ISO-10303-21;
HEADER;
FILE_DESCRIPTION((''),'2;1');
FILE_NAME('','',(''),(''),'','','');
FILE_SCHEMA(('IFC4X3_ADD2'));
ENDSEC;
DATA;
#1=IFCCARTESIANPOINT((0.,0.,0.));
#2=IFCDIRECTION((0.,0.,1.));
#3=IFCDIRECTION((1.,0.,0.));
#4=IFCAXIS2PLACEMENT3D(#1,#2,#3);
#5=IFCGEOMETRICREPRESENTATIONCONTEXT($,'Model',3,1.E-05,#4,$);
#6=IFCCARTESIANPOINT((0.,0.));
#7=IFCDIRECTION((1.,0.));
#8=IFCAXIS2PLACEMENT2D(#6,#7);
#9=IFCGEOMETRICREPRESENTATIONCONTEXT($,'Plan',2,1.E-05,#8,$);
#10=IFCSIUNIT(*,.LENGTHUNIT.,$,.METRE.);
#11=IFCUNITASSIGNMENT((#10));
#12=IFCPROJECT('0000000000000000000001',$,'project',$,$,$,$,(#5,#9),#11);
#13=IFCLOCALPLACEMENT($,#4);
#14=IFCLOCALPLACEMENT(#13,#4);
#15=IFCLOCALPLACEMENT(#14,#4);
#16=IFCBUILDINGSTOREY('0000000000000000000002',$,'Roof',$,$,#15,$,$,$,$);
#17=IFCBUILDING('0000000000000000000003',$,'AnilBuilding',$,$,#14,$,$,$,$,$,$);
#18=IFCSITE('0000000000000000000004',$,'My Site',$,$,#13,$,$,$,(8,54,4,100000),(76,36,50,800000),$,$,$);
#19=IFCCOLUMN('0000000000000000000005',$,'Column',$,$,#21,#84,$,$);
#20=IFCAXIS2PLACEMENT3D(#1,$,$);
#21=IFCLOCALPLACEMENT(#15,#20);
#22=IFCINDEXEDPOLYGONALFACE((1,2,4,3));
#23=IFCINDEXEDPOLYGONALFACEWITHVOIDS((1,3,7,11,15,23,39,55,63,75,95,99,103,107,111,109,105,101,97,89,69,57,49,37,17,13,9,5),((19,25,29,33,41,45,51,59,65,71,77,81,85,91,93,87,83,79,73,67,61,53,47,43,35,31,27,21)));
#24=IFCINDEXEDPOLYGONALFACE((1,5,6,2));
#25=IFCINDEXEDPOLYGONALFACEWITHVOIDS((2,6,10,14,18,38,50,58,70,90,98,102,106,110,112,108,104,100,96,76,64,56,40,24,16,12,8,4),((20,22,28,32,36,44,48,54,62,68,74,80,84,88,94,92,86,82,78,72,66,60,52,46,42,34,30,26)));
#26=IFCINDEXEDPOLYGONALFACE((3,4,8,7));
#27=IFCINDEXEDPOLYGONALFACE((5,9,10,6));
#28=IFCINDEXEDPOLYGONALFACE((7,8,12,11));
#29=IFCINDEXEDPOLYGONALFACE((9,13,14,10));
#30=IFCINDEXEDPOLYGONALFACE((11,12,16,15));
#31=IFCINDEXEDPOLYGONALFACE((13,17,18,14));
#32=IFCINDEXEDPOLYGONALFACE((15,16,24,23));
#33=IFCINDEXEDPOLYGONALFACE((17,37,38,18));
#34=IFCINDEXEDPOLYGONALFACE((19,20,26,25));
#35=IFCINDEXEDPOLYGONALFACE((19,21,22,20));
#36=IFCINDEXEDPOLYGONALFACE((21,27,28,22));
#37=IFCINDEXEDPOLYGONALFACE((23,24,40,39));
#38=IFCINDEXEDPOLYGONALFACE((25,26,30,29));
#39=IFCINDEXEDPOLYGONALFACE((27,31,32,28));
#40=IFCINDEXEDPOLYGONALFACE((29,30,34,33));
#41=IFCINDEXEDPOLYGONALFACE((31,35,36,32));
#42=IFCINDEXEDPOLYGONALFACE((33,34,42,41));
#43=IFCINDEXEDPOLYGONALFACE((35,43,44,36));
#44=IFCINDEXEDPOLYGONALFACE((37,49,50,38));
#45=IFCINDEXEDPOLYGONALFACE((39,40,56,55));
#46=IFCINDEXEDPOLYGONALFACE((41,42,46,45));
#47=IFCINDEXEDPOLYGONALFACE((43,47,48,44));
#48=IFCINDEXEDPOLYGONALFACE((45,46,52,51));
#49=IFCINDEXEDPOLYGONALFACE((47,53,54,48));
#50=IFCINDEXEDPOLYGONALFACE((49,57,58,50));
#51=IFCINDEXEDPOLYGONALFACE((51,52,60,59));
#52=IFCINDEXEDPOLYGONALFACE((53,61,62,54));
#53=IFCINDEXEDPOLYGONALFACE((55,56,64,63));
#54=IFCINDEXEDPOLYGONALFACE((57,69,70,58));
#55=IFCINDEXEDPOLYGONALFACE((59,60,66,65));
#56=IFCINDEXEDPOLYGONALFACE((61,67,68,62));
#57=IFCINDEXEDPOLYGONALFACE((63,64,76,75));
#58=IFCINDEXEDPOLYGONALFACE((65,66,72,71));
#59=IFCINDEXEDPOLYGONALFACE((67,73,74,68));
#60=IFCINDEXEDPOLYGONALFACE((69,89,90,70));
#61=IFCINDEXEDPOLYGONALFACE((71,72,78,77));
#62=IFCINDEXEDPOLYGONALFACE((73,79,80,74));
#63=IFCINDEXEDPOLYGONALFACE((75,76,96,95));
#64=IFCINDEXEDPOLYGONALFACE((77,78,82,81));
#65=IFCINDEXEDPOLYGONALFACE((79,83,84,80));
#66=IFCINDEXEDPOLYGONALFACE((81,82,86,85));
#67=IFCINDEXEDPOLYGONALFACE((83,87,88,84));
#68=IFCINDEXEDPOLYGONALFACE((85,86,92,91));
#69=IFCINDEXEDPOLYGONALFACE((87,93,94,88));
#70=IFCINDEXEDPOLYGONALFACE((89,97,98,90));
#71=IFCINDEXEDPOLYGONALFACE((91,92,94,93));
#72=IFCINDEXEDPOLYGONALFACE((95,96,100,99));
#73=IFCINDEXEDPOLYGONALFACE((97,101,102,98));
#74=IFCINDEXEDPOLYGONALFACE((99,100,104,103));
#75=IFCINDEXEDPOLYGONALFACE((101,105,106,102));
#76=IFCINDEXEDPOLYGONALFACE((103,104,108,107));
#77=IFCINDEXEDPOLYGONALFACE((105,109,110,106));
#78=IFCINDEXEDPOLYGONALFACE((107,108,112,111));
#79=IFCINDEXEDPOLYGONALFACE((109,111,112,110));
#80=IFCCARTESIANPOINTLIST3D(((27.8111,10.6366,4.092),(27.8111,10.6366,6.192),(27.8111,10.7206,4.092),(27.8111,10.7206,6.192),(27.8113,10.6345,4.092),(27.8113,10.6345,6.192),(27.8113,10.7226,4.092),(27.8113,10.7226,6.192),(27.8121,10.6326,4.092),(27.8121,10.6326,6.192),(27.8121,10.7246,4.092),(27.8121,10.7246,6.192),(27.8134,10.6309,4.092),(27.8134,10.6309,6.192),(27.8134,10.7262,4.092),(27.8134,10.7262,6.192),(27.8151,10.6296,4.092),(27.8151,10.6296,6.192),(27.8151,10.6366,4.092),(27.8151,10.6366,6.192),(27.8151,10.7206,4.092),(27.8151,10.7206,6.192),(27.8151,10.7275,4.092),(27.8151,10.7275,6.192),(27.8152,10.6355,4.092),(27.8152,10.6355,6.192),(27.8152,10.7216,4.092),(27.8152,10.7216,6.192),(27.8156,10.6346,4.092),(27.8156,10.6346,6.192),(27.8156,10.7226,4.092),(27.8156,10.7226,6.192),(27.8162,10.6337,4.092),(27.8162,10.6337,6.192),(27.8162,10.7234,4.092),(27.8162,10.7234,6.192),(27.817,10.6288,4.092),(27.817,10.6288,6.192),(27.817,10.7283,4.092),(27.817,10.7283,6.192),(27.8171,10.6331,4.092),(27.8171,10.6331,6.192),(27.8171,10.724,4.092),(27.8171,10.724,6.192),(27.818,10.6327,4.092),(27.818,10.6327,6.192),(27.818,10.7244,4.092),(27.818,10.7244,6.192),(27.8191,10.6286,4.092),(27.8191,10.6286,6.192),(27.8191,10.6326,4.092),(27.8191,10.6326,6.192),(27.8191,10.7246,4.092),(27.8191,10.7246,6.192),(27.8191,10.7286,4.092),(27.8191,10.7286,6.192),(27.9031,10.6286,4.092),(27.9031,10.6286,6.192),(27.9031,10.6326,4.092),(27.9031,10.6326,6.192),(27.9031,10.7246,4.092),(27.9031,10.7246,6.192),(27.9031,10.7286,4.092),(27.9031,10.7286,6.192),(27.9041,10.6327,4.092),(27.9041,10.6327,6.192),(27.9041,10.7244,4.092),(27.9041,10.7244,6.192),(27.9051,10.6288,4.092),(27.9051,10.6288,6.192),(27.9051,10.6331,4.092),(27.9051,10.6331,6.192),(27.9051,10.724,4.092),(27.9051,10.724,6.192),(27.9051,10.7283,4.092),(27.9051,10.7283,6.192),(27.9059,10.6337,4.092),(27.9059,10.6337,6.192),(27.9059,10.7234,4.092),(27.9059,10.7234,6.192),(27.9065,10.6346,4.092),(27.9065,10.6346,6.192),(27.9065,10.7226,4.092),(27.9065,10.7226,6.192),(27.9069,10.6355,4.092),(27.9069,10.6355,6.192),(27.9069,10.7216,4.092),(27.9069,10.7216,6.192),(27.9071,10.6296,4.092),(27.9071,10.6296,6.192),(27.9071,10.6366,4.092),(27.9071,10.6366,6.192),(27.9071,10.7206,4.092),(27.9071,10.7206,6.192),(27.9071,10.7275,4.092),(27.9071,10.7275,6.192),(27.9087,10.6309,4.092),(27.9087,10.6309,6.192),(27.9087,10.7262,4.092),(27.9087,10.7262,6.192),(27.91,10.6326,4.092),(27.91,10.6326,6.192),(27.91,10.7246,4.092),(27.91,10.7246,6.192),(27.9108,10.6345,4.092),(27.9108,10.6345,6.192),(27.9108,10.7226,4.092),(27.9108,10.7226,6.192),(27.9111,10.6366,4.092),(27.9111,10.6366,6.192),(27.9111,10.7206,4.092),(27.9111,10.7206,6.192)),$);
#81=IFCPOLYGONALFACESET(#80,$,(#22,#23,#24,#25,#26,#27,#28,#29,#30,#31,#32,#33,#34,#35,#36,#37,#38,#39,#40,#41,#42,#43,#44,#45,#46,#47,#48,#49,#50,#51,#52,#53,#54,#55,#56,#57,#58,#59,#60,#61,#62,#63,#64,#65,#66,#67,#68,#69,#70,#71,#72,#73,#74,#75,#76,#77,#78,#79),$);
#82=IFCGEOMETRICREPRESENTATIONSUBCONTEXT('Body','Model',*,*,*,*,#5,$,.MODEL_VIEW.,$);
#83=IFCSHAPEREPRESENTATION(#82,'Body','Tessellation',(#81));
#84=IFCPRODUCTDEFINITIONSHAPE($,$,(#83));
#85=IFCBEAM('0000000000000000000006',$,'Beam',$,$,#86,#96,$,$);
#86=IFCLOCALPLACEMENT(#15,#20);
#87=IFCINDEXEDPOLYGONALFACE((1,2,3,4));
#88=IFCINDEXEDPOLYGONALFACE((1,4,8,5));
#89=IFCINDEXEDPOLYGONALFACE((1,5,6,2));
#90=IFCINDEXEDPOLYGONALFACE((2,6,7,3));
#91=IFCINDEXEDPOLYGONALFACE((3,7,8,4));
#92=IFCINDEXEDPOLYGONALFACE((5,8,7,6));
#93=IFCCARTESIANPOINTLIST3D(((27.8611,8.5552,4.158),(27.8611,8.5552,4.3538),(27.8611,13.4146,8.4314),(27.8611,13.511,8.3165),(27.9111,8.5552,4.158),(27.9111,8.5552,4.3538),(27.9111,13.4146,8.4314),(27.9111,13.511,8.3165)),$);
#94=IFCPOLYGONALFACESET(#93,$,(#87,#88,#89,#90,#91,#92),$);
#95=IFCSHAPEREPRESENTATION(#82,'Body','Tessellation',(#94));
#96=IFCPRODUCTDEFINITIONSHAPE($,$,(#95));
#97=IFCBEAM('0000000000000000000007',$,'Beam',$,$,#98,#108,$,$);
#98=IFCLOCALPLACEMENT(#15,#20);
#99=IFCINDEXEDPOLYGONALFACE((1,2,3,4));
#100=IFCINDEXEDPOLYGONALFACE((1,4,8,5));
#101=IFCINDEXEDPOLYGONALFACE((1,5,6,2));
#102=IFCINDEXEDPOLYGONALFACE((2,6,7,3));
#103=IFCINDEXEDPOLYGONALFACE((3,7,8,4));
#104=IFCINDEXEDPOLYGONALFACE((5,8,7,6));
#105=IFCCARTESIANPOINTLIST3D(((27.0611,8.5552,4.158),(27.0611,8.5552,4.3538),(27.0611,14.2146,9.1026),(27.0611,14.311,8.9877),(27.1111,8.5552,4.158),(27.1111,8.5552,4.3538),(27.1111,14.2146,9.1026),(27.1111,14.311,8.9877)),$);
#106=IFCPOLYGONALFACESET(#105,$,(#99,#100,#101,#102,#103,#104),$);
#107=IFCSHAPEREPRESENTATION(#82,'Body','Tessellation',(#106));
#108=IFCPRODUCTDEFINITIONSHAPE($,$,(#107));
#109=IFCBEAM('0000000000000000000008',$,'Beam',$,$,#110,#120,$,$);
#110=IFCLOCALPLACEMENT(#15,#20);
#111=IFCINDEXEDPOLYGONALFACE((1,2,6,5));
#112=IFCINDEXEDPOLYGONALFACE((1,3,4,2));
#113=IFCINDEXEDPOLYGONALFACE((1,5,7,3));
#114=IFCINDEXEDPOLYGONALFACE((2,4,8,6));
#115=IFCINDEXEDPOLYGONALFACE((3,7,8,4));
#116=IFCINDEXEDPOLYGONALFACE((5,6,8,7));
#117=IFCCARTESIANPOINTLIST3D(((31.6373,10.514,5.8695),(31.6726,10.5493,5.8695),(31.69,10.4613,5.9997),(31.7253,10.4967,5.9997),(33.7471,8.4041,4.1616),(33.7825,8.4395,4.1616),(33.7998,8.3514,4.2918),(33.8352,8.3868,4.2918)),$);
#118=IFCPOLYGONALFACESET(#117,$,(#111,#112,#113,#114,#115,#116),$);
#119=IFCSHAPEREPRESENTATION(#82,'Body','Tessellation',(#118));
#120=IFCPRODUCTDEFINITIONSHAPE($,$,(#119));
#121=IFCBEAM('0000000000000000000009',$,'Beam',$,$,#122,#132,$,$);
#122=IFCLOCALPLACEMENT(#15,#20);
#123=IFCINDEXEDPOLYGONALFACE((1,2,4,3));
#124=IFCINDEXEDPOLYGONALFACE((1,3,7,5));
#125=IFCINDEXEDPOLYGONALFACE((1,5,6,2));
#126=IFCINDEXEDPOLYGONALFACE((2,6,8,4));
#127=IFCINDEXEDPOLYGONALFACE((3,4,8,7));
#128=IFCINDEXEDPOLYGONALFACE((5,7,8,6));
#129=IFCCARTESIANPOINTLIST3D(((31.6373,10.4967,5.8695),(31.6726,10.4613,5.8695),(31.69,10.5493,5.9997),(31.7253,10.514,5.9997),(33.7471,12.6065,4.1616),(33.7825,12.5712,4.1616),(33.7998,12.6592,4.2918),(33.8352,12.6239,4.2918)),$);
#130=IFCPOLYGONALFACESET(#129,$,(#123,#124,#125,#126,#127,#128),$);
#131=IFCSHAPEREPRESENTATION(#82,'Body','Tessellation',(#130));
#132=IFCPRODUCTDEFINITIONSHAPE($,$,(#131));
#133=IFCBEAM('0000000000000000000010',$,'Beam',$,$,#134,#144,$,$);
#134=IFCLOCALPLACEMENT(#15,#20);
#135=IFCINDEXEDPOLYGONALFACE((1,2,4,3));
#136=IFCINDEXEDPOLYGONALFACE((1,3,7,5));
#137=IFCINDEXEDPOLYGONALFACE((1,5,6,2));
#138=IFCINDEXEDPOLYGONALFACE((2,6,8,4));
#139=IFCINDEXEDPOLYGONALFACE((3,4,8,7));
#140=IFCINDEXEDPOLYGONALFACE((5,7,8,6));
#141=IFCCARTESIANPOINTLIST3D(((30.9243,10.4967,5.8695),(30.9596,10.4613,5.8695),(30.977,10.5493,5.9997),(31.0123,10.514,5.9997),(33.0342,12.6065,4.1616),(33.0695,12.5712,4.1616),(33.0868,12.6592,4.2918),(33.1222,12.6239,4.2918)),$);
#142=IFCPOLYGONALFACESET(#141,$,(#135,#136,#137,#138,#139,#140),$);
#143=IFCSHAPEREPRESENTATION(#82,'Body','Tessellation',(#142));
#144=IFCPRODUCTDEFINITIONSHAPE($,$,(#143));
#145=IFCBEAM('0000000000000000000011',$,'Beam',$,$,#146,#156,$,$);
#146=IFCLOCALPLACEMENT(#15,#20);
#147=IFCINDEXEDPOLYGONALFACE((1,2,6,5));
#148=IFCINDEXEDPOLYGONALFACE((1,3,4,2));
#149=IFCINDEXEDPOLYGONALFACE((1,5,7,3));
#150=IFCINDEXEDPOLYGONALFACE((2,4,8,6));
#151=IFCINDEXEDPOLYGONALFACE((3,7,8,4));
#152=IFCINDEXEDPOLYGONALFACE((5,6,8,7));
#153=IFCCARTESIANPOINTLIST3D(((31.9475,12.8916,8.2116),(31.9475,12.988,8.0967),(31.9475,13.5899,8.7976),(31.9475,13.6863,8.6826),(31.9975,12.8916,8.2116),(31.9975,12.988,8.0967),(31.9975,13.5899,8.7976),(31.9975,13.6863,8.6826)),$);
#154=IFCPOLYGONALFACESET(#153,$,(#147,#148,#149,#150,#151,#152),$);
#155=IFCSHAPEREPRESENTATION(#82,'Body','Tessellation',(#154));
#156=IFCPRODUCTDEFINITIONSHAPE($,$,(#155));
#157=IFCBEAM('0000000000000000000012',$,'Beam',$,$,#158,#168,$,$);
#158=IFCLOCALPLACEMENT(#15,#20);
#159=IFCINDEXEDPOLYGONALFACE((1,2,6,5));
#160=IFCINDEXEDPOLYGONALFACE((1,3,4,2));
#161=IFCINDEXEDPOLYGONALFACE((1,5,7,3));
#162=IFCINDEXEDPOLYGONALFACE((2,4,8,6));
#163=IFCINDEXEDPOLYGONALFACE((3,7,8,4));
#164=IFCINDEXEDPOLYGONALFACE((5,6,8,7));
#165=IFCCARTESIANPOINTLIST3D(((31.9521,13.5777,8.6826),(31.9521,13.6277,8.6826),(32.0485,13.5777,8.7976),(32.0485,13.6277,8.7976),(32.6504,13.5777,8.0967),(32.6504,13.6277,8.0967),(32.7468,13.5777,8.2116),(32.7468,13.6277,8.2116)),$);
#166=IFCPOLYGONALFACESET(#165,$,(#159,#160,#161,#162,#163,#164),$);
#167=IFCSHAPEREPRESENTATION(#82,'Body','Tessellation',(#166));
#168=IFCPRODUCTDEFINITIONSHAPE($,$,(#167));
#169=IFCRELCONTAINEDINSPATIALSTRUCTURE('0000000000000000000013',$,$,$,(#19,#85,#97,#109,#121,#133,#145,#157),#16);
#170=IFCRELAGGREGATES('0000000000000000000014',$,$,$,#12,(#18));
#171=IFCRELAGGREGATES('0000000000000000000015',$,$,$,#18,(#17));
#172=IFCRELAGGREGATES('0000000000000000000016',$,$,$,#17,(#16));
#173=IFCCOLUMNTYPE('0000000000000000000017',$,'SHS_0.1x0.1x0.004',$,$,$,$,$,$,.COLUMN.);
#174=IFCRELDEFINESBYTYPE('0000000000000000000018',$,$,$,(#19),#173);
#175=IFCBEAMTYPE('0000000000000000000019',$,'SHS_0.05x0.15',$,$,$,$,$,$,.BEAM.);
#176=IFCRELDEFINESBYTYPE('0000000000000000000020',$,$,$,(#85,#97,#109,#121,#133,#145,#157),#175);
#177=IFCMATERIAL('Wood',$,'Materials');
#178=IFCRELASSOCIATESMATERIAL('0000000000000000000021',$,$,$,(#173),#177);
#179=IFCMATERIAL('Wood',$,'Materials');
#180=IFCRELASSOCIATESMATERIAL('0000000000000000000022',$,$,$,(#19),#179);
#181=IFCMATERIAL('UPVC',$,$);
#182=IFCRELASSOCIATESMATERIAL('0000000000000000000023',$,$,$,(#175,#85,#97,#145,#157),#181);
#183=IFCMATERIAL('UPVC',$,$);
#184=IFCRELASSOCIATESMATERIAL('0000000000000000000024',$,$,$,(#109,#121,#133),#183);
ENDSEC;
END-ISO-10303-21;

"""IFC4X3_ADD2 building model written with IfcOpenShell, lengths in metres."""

from ifc_helpers import new_model, entity, si_unit, frame, origin_with_axes, origin_2d_with_axis, place, context, subcontext, project, spatial, indexed_curve, hollow_rectangle, outline, extrude, clip, halfspace, shape, material, material_profile, profile_set, profile_usage, type_object, element, save


model = new_model("IFC4X3_ADD2")

# Units and contexts
model_context = context("Model", 3, precision=1e-05, world=origin_with_axes())
plan_context = context("Plan", 2, precision=1e-05, world=origin_2d_with_axis())
body_context_1 = subcontext(model_context, "Body", "Model", "MODEL_VIEW")
body_context_2 = subcontext(plan_context, "Body", "Plan", "PLAN_VIEW")
ifc_project = project(units=[si_unit("LENGTHUNIT", "METRE")], contexts=[model_context, plan_context])

# Site, building, storey
site_placement = place(None, origin_with_axes())
site = spatial("IfcSite", under=ifc_project, at=site_placement, Name="My Site", RefLatitude=(8, 54, 4, 100000), RefLongitude=(76, 36, 50, 800000))
building_placement = place(site_placement, origin_with_axes())
building = spatial("IfcBuilding", under=site, at=building_placement, Name="AnilBuilding")
storey_placement = place(building_placement, origin_with_axes())
storey = spatial("IfcBuildingStorey", under=building, at=storey_placement, Name="Roof")

# Column
ifc_material_1 = material(Name="Wood", Category="Materials")
ifc_material_profile_1 = material_profile(ifc_material_1, hollow_rectangle(XDim=0.1, YDim=0.1, WallThickness=0.004, InnerFilletRadius=0.004, OuterFilletRadius=0.008))
ifc_profile_set_1 = profile_set([ifc_material_profile_1])
ifc_profile_usage_1 = profile_usage(ifc_profile_set_1)
ifc_material_2 = material(Name="Wood", Category="Materials")
ifc_material_profile_2 = material_profile(ifc_material_2, hollow_rectangle(XDim=0.1, YDim=0.1, WallThickness=0.004, InnerFilletRadius=0.004, OuterFilletRadius=0.008))
ifc_profile_set_2 = profile_set([ifc_material_profile_2])
column_type = type_object("IfcColumnType", Name="SHS_0.1x0.1x0.004", PredefinedType="COLUMN", material=ifc_profile_set_2)
column_placement = place(storey_placement, frame((27.8611, 10.6786, 4.092), z_axis=(0.0, 0.0, 1.0), x_axis=(0.0, -1.0, 0.0)))
element("IfcColumn", 1, at=column_placement, inside=storey, type_object=column_type, material=ifc_profile_usage_1, Name="Column", shapes=[
    shape(body_context_1, "Body", "SweptSolid", [extrude(hollow_rectangle(XDim=0.1, YDim=0.1, WallThickness=0.004, InnerFilletRadius=0.004, OuterFilletRadius=0.008), origin_with_axes(), (0.0, 0.0, 1.0), 2.1)]),
    shape(body_context_2, "Body", "Annotation2D", [entity("IfcGeometricCurveSet", [entity("IfcIndexedPolyCurve", entity("IfcCartesianPointList2D", [[0.04, -0.04], [0.04, 0.04], [-0.04, 0.04], [-0.04, -0.04]]), [entity("IfcLineIndex", [1, 2, 3, 4, 1])]), entity("IfcIndexedPolyCurve", entity("IfcCartesianPointList2D", [[-0.05, -0.05], [0.05, -0.05], [0.05, 0.05], [-0.05, 0.05]]), [entity("IfcLineIndex", [1, 2, 3, 4, 1])])])]),
])

# Beams
ifc_material_3 = material(Name="UPVC")
ifc_material_profile_3 = material_profile(ifc_material_3, outline(indexed_curve([(-0.025, 0.075), (0.025, 0.075), (0.025, -0.075), (-0.025, -0.075), (-0.025, 0.075)])))
ifc_profile_set_3 = profile_set([ifc_material_profile_3])
ifc_profile_usage_2 = profile_usage(ifc_profile_set_3, cardinal=5)
beam_type = type_object("IfcBeamType", Name="SHS_0.05x0.15", PredefinedType="BEAM", material=ifc_profile_set_3)
beam_1_placement = place(storey_placement, frame((27.8861, 8.4403, 4.1595), z_axis=(0.000001, 0.766044, 0.642788), x_axis=(-1.0, 0.000001, 0.0)))
element("IfcBeam", 2, at=beam_1_placement, inside=storey, type_object=beam_type, material=ifc_profile_usage_2, Name="Beam", context=body_context_1, shape_type="Clipping", body=[
    clip(extrude(outline(indexed_curve([(-0.025, 0.075), (0.025, 0.075), (0.025, -0.075), (-0.025, -0.075), (-0.025, 0.075)])), origin_with_axes(), (0.0, 0.0, 1.0), 6.5565), halfspace(frame((12.1745, -0.0793, 0.0835), z_axis=(0.0, 0.642787, -0.766045), x_axis=(1.0, -0.000001, 0.0)), False)),
])
ifc_profile_usage_3 = profile_usage(ifc_profile_set_3, cardinal=5)
beam_2_placement = place(storey_placement, frame((27.0861, 8.4403, 4.1595), z_axis=(0.000001, 0.766044, 0.642788), x_axis=(-1.0, 0.000001, 0.0)))
element("IfcBeam", 3, at=beam_2_placement, inside=storey, type_object=beam_type, material=ifc_profile_usage_3, Name="Beam", context=body_context_1, shape_type="Clipping", body=[
    clip(extrude(outline(indexed_curve([(-0.025, 0.075), (0.025, 0.075), (0.025, -0.075), (-0.025, -0.075), (-0.025, 0.075)])), origin_with_axes(), (0.0, 0.0, 1.0), 7.6008), halfspace(frame((11.3745, -0.0793, 0.0835), z_axis=(0.0, 0.642787, -0.766045), x_axis=(1.0, -0.000001, 0.0)), False)),
])
ifc_material_4 = material(Name="UPVC")
ifc_material_profile_4 = material_profile(ifc_material_4, outline(indexed_curve([(-0.025, 0.075), (0.025, 0.075), (0.025, -0.075), (-0.025, -0.075), (-0.025, 0.075)])))
ifc_profile_set_4 = profile_set([ifc_material_profile_4])
ifc_profile_usage_4 = profile_usage(ifc_profile_set_4, cardinal=5)
beam_3_placement = place(storey_placement, frame((31.6813, 10.5053, 5.9346), z_axis=(0.61369, -0.613688, -0.496761), x_axis=(0.707106, 0.707107, 0.0)))
element("IfcBeam", 4, at=beam_3_placement, inside=storey, type_object=beam_type, material=ifc_profile_usage_4, Name="Beam", context=body_context_1, shape_type="SweptSolid", body=[
    extrude(outline(indexed_curve([(-0.025, 0.075), (0.025, 0.075), (0.025, -0.075), (-0.025, -0.075), (-0.025, 0.075)])), origin_with_axes(), (0.0, 0.0, 1.0), 3.438),
])
ifc_profile_usage_5 = profile_usage(ifc_profile_set_4, cardinal=5)
beam_4_placement = place(storey_placement, frame((31.6813, 10.5053, 5.9346), z_axis=(0.613688, 0.61369, -0.496761), x_axis=(-0.707108, 0.707106, 0.0)))
element("IfcBeam", 5, at=beam_4_placement, inside=storey, type_object=beam_type, material=ifc_profile_usage_5, Name="Beam", context=body_context_1, shape_type="SweptSolid", body=[
    extrude(outline(indexed_curve([(-0.025, 0.075), (0.025, 0.075), (0.025, -0.075), (-0.025, -0.075), (-0.025, 0.075)])), origin_with_axes(), (0.0, 0.0, 1.0), 3.438),
])
ifc_profile_usage_6 = profile_usage(ifc_profile_set_4, cardinal=5)
beam_5_placement = place(storey_placement, frame((30.9683, 10.5053, 5.9346), z_axis=(0.613688, 0.61369, -0.496761), x_axis=(-0.707108, 0.707106, 0.0)))
element("IfcBeam", 6, at=beam_5_placement, inside=storey, type_object=beam_type, material=ifc_profile_usage_6, Name="Beam", context=body_context_1, shape_type="SweptSolid", body=[
    extrude(outline(indexed_curve([(-0.025, 0.075), (0.025, 0.075), (0.025, -0.075), (-0.025, -0.075), (-0.025, 0.075)])), origin_with_axes(), (0.0, 0.0, 1.0), 3.438),
])
ifc_profile_usage_7 = profile_usage(ifc_profile_set_3, cardinal=5)
beam_6_placement = place(storey_placement, frame((31.9725, 13.6381, 8.7401), z_axis=(0.0, -0.766044, -0.642788), x_axis=(-1.0, 0.0, 0.0)))
element("IfcBeam", 7, at=beam_6_placement, inside=storey, type_object=beam_type, material=ifc_profile_usage_7, Name="Beam", context=body_context_1, shape_type="SweptSolid", body=[
    extrude(outline(indexed_curve([(-0.025, 0.075), (0.025, 0.075), (0.025, -0.075), (-0.025, -0.075), (-0.025, 0.075)])), origin_with_axes(), (0.0, 0.0, 1.0), 0.9115),
])
ifc_profile_usage_8 = profile_usage(ifc_profile_set_3, cardinal=5)
beam_7_placement = place(storey_placement, frame((32.0003, 13.6027, 8.7401), z_axis=(0.766045, -0.000001, -0.642787), x_axis=(-0.000001, -1.0, 0.0)))
element("IfcBeam", 8, at=beam_7_placement, inside=storey, type_object=beam_type, material=ifc_profile_usage_8, Name="Beam", context=body_context_1, shape_type="SweptSolid", body=[
    extrude(outline(indexed_curve([(-0.025, 0.075), (0.025, 0.075), (0.025, -0.075), (-0.025, -0.075), (-0.025, 0.075)])), origin_with_axes(), (0.0, 0.0, 1.0), 0.9115),
])

save(model, "model.ifc")
